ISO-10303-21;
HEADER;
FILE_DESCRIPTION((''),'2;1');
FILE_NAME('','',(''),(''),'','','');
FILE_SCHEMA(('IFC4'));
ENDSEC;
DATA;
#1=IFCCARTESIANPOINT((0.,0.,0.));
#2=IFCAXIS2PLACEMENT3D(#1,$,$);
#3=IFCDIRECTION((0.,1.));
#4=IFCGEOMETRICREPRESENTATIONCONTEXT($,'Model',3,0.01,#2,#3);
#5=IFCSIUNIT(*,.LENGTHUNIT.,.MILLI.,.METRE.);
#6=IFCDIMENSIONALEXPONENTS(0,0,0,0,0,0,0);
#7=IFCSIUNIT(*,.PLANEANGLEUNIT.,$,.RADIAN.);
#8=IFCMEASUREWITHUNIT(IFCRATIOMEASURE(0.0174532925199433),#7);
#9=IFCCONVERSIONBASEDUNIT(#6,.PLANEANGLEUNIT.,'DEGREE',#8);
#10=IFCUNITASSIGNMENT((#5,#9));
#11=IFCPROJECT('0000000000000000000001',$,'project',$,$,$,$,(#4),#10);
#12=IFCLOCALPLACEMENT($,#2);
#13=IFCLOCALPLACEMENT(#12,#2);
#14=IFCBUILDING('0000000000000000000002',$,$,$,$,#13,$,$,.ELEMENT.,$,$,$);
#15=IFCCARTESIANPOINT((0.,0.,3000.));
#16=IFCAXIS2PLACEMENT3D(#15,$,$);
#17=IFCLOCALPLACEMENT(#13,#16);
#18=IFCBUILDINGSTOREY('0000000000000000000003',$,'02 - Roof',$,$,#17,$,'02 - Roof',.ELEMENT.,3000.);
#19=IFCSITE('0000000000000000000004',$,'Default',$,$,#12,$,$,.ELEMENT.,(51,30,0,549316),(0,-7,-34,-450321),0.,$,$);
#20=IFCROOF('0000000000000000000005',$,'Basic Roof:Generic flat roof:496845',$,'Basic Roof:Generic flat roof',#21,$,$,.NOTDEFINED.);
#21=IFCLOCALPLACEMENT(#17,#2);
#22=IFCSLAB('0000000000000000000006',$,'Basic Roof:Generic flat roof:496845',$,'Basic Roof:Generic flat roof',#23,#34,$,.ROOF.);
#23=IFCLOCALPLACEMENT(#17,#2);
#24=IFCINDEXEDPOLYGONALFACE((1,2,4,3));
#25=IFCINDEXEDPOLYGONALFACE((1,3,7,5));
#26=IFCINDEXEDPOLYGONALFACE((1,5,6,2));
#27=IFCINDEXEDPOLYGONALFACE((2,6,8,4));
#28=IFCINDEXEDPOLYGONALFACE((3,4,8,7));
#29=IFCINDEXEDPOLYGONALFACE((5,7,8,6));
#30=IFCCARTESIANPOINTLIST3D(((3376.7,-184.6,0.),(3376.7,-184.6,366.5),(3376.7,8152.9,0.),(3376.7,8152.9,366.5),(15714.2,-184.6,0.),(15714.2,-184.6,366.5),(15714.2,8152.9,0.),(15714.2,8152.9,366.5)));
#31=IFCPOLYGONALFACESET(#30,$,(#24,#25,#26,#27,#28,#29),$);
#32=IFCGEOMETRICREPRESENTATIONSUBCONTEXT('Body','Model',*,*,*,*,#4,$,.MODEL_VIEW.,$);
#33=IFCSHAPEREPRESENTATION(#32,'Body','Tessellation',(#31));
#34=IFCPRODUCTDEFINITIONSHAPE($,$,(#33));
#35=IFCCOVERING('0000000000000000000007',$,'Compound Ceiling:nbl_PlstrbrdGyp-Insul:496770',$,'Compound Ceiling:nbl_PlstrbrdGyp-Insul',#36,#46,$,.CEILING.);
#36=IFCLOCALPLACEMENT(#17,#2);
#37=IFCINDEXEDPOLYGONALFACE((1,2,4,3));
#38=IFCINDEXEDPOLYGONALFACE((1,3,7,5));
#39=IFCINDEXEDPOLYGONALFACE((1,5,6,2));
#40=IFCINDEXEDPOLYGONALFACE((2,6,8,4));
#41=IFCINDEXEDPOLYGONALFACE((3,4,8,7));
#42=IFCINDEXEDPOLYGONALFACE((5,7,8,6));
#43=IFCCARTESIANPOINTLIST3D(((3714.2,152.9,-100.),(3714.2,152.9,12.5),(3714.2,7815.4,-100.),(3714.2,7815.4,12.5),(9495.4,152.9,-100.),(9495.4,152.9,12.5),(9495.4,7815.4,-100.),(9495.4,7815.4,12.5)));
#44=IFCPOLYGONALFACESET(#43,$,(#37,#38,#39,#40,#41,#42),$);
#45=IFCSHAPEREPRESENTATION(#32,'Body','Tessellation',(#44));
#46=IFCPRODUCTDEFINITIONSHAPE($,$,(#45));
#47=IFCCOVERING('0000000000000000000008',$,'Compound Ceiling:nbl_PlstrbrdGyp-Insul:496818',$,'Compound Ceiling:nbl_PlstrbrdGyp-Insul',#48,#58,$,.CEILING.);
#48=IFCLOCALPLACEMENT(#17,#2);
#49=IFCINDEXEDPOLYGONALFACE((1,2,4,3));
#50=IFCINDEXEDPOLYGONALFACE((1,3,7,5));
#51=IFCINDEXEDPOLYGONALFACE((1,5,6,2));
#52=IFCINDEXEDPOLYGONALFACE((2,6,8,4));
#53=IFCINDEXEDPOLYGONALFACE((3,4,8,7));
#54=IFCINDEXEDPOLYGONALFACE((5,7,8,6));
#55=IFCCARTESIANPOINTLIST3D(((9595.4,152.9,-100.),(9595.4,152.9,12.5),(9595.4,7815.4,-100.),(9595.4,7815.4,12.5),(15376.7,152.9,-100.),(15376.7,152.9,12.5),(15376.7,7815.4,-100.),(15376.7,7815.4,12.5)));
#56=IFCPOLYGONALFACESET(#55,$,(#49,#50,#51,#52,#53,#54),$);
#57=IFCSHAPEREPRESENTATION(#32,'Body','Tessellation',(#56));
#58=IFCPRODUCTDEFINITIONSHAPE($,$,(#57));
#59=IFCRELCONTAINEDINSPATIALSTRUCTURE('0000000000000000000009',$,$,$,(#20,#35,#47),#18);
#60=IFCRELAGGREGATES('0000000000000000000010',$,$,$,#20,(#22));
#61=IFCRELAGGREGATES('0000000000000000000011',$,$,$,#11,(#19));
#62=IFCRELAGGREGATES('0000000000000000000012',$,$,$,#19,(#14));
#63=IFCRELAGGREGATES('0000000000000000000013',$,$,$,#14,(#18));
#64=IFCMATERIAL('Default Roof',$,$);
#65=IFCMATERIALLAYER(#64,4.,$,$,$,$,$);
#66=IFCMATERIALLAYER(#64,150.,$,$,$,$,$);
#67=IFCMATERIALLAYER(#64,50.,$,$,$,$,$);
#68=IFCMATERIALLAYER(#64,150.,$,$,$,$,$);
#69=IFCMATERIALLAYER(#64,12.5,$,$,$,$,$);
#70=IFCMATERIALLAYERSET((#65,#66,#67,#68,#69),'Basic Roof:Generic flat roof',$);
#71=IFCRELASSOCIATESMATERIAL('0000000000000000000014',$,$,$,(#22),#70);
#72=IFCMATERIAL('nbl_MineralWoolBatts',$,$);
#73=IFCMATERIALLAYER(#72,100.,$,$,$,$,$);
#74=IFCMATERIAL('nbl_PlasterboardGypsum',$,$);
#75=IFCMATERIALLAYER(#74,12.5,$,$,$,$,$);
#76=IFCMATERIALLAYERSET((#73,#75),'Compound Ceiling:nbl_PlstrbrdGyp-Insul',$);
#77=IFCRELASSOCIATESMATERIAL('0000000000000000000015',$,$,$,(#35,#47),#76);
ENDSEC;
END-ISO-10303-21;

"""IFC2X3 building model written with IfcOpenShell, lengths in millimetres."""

from ifc_helpers import new_model, entity, si_unit, converted_unit, direction, frame, frame_2d, origin, origin_2d_with_axis, place, context, subcontext, project, spatial, rectangle, extrude, material, layer, layer_set, layer_usage, element, aggregate, save


model = new_model("IFC2X3")

# Units and contexts
model_context = context("Model", 3, precision=0.01, world=origin(), true_north=direction((0.0, 1.0)))
body_context = subcontext(model_context, "Body", "Model", "MODEL_VIEW")
ifc_project = project(units=[si_unit("LENGTHUNIT", "METRE", prefix="MILLI"), converted_unit("PLANEANGLEUNIT", "DEGREE", entity("IfcRatioMeasure", 0.0174532925199433), si_unit("PLANEANGLEUNIT", "RADIAN"), dimensions=[0, 0, 0, 0, 0, 0, 0])], contexts=[model_context])

# Site, building, storey
site_placement = place(None, origin())
site = spatial("IfcSite", under=ifc_project, at=site_placement, Name="Default", CompositionType="ELEMENT", RefLatitude=(51, 30, 0, 549316), RefLongitude=(0, -7, -34, -450321), RefElevation=0.0)
building_placement = place(site_placement, origin())
building = spatial("IfcBuilding", under=site, at=building_placement, CompositionType="ELEMENT")
storey_placement = place(building_placement, frame((0.0, 0.0, 3000.0)))
storey = spatial("IfcBuildingStorey", under=building, at=storey_placement, Name="02 - Roof", LongName="02 - Roof", CompositionType="ELEMENT", Elevation=3000.0)

# Roof, slab
roof_placement = place(storey_placement, frame((3376.7, -184.6, 0.0)))
roof = element("IfcRoof", 1, at=roof_placement, inside=storey, Name="Basic Roof:Generic flat roof:496845", ObjectType="Basic Roof:Generic flat roof", ShapeType="NOTDEFINED")
ifc_material_1 = material(Name="Default Roof")
ifc_layer_1 = layer(ifc_material_1, 4.0)
ifc_layer_2 = layer(ifc_material_1, 150.0)
ifc_layer_3 = layer(ifc_material_1, 50.0)
ifc_layer_4 = layer(ifc_material_1, 150.0)
ifc_layer_5 = layer(ifc_material_1, 12.5)
ifc_layer_set_1 = layer_set([ifc_layer_1, ifc_layer_2, ifc_layer_3, ifc_layer_4, ifc_layer_5], Name="Basic Roof:Generic flat roof")
slab_placement = place(roof_placement, origin())
slab = element("IfcSlab", 2, at=slab_placement, material=ifc_layer_set_1, Name="Basic Roof:Generic flat roof:496845", ObjectType="Basic Roof:Generic flat roof", PredefinedType="ROOF", context=body_context, shape_type="SweptSolid", body=[
    extrude(rectangle(XDim=12337.5, YDim=8337.5, at=origin_2d_with_axis()), frame((6168.7, 4168.8, 0.0)), (0.0, 0.0, 1.0), 366.5),
])
aggregate(roof, [slab])

# Coverings
ifc_material_2 = material(Name="nbl_MineralWoolBatts")
ifc_layer_6 = layer(ifc_material_2, 100.0)
ifc_material_3 = material(Name="nbl_PlasterboardGypsum")
ifc_layer_7 = layer(ifc_material_3, 12.5)
ifc_layer_set_2 = layer_set([ifc_layer_6, ifc_layer_7], Name="Compound Ceiling:nbl_PlstrbrdGyp-Insul")
ifc_layer_usage_1 = layer_usage(ifc_layer_set_2, "AXIS3", "NEGATIVE", 0.0)
covering_1_placement = place(storey_placement, origin())
element("IfcCovering", 3, at=covering_1_placement, inside=storey, material=ifc_layer_usage_1, Name="Compound Ceiling:nbl_PlstrbrdGyp-Insul:496770", ObjectType="Compound Ceiling:nbl_PlstrbrdGyp-Insul", PredefinedType="CEILING", context=body_context, shape_type="SweptSolid", body=[
    extrude(rectangle(XDim=5781.2, YDim=7662.5, at=frame_2d((0.0, 0.0), x_axis=(1.0, 0.0))), frame((6604.8, 3984.1, -100.0), z_axis=(0.0, 0.0, 1.0), x_axis=(-1.0, 0.0, 0.0)), (0.0, 0.0, 1.0), 112.5),
])
ifc_layer_usage_2 = layer_usage(ifc_layer_set_2, "AXIS3", "NEGATIVE", 0.0)
covering_2_placement = place(storey_placement, origin())
element("IfcCovering", 4, at=covering_2_placement, inside=storey, material=ifc_layer_usage_2, Name="Compound Ceiling:nbl_PlstrbrdGyp-Insul:496818", ObjectType="Compound Ceiling:nbl_PlstrbrdGyp-Insul", PredefinedType="CEILING", context=body_context, shape_type="SweptSolid", body=[
    extrude(rectangle(XDim=5781.2, YDim=7662.5, at=origin_2d_with_axis()), frame((12486.1, 3984.1, -100.0), z_axis=(0.0, 0.0, 1.0), x_axis=(-1.0, 0.0, 0.0)), (0.0, 0.0, 1.0), 112.5),
])

save(model, "model.ifc")
